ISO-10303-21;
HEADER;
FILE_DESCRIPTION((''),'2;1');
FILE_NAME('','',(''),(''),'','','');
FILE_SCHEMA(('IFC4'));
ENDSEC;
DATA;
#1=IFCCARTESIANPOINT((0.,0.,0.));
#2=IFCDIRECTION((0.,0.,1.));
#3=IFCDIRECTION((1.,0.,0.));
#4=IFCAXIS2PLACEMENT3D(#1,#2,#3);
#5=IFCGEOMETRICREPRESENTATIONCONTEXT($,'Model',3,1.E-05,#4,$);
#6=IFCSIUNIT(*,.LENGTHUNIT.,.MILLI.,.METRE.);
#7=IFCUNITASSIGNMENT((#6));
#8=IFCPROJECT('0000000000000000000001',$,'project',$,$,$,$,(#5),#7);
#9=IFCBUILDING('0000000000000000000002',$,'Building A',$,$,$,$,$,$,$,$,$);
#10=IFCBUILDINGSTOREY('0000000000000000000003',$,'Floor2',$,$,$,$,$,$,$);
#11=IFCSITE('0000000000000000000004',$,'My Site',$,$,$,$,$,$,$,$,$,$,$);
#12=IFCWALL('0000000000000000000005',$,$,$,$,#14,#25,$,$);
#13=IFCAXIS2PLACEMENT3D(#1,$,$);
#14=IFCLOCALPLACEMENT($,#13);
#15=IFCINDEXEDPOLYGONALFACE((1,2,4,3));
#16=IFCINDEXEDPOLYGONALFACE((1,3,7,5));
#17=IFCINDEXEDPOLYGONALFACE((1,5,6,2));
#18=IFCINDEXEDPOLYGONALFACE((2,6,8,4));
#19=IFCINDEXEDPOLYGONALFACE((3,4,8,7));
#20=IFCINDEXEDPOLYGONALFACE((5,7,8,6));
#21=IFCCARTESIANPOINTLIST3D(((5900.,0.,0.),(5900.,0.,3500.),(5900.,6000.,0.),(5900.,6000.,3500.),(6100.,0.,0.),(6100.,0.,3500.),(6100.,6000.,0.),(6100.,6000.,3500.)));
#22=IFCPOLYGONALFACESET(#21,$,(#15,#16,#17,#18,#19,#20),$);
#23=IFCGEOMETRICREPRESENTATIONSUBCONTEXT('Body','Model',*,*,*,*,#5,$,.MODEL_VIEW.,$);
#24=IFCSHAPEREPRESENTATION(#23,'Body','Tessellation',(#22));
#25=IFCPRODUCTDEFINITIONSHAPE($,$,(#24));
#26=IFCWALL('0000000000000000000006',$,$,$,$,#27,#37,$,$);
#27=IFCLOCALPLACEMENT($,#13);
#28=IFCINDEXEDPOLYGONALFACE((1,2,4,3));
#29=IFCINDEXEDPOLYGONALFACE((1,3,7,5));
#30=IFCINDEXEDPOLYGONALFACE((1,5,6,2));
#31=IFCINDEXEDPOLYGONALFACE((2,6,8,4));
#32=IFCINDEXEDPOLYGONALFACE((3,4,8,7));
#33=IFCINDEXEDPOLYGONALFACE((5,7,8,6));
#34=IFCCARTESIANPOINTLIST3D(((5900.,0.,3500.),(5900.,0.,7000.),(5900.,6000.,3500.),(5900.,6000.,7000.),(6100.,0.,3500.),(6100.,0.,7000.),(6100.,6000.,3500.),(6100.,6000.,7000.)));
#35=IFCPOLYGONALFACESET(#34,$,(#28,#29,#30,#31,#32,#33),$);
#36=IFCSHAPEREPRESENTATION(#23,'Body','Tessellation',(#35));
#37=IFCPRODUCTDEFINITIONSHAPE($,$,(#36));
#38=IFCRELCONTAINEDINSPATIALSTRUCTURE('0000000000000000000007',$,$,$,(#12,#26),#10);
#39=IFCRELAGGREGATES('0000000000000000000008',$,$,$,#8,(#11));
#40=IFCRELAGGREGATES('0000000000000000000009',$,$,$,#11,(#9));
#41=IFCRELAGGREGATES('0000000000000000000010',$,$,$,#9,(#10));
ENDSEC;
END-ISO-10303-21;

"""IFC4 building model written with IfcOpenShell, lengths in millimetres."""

from ifc_helpers import new_model, si_unit, frame, origin_with_axes, place, context, subcontext, project, spatial, indexed_curve, outline, extrude, element, save


model = new_model("IFC4")

# Units and contexts
model_context = context("Model", 3, precision=1e-05, world=origin_with_axes())
body_context = subcontext(model_context, "Body", "Model", "MODEL_VIEW")
ifc_project = project(units=[si_unit("LENGTHUNIT", "METRE", prefix="MILLI")], contexts=[model_context])

# Site, building, storey
site = spatial("IfcSite", under=ifc_project, Name="My Site")
building = spatial("IfcBuilding", under=site, Name="Building A")
storey = spatial("IfcBuildingStorey", under=building, Name="Floor2")

# Walls
for number, where, z_axis, x_axis in (
    (1, (6100.0, 0.0, 0.0), (0.0, 0.0, 1.0), (0.0, 1.0, 0.0)),
    (2, (6100.0, 0.0, 3500.0), (0.0, 0.0, 1.0), (0.0, 1.0, 0.0)),
):
    element("IfcWall", number, at=place(None, frame(where, z_axis=z_axis, x_axis=x_axis)), inside=storey, context=body_context, shape_type="SweptSolid", body=[
        extrude(outline(indexed_curve([(0.0, 0.0), (0.0, 200.0), (6000.0, 200.0), (6000.0, 0.0), (0.0, 0.0)], self_intersect=False)), origin_with_axes(), (0.0, 0.0, 1.0), 3500.0),
    ])

save(model, "model.ifc")
